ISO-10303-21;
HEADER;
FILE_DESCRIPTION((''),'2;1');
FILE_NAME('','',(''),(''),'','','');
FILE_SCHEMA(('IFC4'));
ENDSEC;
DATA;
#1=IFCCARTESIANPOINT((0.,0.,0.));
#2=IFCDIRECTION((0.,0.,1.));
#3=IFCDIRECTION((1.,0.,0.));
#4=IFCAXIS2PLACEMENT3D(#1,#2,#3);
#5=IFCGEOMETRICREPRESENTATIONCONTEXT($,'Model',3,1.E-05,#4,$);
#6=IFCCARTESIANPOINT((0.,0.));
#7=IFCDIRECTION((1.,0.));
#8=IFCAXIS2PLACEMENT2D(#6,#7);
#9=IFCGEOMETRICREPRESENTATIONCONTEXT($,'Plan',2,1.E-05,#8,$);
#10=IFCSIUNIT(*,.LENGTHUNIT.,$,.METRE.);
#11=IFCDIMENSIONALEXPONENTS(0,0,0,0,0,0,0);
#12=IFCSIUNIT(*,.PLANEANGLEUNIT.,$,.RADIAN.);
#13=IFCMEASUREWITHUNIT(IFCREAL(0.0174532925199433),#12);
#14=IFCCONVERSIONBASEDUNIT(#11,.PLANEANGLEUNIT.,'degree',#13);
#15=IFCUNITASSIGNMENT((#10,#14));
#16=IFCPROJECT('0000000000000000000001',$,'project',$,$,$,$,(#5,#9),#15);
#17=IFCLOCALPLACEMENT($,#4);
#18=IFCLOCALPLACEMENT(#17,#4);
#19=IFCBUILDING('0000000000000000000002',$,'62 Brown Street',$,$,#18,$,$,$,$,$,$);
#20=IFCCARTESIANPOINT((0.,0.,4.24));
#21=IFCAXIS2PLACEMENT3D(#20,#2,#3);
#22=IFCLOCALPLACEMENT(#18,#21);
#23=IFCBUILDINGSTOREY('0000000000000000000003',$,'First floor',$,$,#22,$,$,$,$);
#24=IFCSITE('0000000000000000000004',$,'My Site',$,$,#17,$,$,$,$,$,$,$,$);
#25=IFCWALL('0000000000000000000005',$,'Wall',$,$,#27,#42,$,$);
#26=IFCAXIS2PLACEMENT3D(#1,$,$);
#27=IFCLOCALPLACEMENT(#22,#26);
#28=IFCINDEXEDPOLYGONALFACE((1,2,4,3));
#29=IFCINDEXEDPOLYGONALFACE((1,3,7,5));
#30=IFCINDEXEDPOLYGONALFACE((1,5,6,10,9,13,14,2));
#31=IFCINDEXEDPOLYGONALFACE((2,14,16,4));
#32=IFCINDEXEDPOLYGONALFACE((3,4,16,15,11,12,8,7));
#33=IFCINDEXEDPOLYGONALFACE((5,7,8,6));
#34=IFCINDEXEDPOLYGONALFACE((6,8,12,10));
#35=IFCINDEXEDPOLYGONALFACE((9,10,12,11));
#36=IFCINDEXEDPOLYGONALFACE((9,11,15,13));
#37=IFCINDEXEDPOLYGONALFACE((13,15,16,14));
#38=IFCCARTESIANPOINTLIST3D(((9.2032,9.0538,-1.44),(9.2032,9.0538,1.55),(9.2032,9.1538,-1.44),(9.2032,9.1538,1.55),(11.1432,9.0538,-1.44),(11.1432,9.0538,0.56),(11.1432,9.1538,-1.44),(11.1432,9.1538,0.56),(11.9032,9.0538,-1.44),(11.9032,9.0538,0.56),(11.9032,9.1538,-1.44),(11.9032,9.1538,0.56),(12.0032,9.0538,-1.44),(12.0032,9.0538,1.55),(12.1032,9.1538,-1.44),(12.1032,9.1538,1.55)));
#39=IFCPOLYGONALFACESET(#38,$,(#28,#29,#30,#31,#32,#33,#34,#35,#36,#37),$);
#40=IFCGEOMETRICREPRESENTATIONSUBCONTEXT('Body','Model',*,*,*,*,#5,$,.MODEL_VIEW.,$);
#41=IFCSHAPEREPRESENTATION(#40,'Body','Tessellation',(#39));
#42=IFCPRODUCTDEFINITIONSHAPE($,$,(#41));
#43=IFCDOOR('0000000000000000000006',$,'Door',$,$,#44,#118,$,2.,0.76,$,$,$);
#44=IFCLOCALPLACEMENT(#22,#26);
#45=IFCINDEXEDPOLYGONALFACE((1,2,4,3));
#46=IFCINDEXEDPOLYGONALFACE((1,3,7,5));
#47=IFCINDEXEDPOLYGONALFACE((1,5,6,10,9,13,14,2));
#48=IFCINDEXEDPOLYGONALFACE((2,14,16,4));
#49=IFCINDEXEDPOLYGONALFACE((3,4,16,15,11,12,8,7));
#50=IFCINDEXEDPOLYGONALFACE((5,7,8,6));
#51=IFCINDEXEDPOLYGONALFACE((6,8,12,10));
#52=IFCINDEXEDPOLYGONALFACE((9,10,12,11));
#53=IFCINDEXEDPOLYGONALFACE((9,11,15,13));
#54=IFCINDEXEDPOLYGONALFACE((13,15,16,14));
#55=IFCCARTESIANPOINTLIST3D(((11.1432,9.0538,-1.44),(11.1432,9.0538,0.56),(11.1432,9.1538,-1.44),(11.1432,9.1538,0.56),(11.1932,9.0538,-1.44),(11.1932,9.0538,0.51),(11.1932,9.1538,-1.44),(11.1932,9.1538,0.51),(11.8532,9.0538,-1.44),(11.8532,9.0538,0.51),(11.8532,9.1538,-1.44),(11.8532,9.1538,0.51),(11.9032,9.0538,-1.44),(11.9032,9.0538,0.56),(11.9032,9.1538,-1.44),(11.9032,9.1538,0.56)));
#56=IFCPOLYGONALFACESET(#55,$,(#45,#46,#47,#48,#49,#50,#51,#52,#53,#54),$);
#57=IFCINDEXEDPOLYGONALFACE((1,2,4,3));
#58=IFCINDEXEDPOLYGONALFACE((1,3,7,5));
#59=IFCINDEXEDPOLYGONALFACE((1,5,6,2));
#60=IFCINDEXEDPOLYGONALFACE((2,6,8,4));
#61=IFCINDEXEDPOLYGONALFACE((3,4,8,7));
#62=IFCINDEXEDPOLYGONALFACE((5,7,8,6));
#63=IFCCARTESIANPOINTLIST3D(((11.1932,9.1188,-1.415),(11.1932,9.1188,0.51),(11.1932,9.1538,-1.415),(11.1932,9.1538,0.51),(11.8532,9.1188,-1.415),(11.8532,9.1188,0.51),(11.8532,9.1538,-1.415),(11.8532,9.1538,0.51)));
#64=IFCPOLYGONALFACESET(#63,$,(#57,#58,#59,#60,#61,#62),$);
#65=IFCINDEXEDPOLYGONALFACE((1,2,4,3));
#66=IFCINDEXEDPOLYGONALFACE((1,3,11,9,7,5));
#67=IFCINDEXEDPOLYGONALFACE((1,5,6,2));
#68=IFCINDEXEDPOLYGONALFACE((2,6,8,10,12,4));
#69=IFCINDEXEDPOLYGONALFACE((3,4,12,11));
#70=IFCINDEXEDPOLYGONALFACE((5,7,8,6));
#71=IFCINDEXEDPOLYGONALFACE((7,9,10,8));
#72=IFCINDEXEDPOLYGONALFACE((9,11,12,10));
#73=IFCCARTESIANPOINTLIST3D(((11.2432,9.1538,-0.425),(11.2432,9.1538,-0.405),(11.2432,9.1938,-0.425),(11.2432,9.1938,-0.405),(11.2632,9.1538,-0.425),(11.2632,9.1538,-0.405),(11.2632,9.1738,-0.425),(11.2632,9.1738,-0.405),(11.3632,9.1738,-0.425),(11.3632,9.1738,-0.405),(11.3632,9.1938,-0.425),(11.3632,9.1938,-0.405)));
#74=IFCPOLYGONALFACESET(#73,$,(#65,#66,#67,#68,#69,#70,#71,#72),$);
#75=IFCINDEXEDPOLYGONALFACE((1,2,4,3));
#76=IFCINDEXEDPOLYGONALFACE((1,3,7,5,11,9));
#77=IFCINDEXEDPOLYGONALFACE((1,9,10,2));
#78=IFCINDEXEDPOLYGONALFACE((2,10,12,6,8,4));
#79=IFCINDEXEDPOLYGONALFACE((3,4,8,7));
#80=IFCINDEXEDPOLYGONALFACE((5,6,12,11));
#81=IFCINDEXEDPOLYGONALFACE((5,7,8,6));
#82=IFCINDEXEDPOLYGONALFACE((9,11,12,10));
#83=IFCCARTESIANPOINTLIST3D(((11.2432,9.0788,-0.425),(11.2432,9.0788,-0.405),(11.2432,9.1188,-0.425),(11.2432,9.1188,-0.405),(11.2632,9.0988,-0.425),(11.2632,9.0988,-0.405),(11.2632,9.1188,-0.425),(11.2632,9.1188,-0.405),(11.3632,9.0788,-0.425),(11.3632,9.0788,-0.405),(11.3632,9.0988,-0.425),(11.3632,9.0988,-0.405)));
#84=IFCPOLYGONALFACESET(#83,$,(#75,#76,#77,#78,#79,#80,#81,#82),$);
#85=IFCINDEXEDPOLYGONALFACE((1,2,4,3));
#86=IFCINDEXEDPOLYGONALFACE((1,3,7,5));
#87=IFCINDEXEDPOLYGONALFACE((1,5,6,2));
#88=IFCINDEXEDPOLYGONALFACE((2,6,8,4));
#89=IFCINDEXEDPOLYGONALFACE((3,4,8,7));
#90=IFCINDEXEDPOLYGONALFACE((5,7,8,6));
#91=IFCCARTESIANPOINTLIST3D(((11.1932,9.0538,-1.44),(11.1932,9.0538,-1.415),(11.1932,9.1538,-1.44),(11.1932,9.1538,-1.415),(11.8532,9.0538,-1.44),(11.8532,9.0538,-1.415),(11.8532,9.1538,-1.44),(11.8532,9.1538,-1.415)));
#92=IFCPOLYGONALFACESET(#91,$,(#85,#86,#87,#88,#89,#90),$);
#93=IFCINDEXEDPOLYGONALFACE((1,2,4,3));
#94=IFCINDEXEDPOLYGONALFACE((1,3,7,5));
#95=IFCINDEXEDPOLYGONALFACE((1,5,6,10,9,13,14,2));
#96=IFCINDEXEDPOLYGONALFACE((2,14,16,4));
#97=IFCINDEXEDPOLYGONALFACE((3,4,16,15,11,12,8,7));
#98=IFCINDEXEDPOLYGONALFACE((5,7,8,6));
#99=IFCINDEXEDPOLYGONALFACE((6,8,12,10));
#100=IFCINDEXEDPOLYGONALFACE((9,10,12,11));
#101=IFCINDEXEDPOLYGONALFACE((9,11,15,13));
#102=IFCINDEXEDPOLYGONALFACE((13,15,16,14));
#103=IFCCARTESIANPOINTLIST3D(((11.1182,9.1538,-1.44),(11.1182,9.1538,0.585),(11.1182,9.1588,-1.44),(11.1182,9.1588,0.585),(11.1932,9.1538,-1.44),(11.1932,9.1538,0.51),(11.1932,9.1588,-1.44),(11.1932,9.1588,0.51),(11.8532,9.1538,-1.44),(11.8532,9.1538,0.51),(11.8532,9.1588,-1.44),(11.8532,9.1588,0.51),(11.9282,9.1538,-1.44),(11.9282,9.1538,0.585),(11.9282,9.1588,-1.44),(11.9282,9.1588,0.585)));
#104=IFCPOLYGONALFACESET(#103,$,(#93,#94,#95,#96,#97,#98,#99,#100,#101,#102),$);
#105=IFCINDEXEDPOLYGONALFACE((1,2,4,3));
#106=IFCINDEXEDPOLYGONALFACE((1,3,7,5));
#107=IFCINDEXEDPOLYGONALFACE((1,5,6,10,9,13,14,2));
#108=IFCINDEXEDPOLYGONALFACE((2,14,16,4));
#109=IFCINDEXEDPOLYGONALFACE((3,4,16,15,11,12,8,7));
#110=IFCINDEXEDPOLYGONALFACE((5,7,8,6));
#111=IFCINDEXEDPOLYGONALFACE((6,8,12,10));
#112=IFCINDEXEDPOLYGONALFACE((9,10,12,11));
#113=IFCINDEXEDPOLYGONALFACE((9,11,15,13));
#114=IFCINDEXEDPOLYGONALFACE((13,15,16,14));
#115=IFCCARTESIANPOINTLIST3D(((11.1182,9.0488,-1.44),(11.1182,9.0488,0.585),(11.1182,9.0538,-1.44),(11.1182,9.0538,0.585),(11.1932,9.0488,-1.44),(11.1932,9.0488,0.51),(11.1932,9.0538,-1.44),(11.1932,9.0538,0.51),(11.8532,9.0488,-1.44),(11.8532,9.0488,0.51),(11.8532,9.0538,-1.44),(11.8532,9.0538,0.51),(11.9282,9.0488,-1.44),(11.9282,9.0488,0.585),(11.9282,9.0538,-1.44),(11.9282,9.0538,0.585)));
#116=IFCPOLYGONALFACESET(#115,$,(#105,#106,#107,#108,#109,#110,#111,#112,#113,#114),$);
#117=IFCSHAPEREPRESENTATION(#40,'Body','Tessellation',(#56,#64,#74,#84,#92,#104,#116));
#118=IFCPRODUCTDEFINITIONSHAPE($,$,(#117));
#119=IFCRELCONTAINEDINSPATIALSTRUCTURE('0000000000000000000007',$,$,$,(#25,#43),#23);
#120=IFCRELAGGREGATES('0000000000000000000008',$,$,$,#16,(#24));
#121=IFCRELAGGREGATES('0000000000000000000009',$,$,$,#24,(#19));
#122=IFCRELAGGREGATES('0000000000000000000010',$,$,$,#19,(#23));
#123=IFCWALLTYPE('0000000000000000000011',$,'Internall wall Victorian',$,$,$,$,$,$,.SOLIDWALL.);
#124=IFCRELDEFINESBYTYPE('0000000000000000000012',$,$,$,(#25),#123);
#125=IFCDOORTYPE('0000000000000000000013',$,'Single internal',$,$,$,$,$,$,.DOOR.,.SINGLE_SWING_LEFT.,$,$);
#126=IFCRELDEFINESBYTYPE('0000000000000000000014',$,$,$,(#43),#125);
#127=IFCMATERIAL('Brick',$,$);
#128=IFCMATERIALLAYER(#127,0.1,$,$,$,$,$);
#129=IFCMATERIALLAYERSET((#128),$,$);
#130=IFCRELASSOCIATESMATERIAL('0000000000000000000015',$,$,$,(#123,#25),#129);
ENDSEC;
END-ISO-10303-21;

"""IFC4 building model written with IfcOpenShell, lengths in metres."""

from ifc_helpers import new_model, entity, si_unit, converted_unit, frame, origin_with_axes, origin_2d_with_axis, place, context, subcontext, project, spatial, line, indexed_curve, outline, extrude, clip, halfspace, shape, source, transform, mapped, material, layer, layer_set, layer_usage, type_object, type_shapes, element, fill, save


model = new_model("IFC4")

# Units and contexts
model_context = context("Model", 3, precision=1e-05, world=origin_with_axes())
plan_context = context("Plan", 2, precision=1e-05, world=origin_2d_with_axis())
body_context_1 = subcontext(model_context, "Body", "Model", "MODEL_VIEW")
body_context_2 = subcontext(plan_context, "Body", "Plan", "PLAN_VIEW")
ifc_project = project(units=[si_unit("LENGTHUNIT", "METRE"), converted_unit("PLANEANGLEUNIT", "degree", entity("IfcReal", 0.0174532925199433), si_unit("PLANEANGLEUNIT", "RADIAN"), dimensions=[0, 0, 0, 0, 0, 0, 0])], contexts=[model_context, plan_context])

# Site, building, storey
site_placement = place(None, origin_with_axes())
site = spatial("IfcSite", under=ifc_project, at=site_placement, Name="My Site")
building_placement = place(site_placement, origin_with_axes())
building = spatial("IfcBuilding", under=site, at=building_placement, Name="62 Brown Street")
storey_placement = place(building_placement, frame((0.0, 0.0, 4.24), z_axis=(0.0, 0.0, 1.0), x_axis=(1.0, 0.0, 0.0)))
storey = spatial("IfcBuildingStorey", under=building, at=storey_placement, Name="First floor")

# Shared definitions
ifc_material_1 = material(Name="Brick")

# Shared definitions
ifc_layer_1 = layer(ifc_material_1, 0.1)
ifc_layer_set_1 = layer_set([ifc_layer_1])
wall_type_1 = type_object("IfcWallType", Name="Internall wall Victorian", PredefinedType="SOLIDWALL", material=ifc_layer_set_1)

# Wall, opening, door
ifc_layer_usage_1 = layer_usage(ifc_layer_set_1, "AXIS2", "POSITIVE", 0.0)
wall_1_placement = place(storey_placement, frame((12.1032, 9.1538, -1.44), z_axis=(0.0, 0.0, 1.0), x_axis=(-1.0, 0.0, 0.0)))
wall_1 = element("IfcWall", 1, at=wall_1_placement, inside=storey, type_object=wall_type_1, material=ifc_layer_usage_1, Name="Wall", context=body_context_1, shape_type="Clipping", body=[
    clip(extrude(outline(indexed_curve([(0.0, 0.0), (0.0, 0.1), (2.9, 0.1), (2.9, 0.0), (0.0, 0.0)], self_intersect=False)), origin_with_axes(), (0.0, 0.0, 1.0), 2.99), halfspace(frame((0.0, 0.0, -2.8), z_axis=(-0.299001, 0.299001, 0.0), x_axis=(0.1, 0.1, 0.0)), False)),
])
shared_shape_1 = source(origin_with_axes(), body_context_1, "Body", "SweptSolid", [
    extrude(outline(indexed_curve([(0.0, 0.0), (0.76, 0.0), (0.76, 2.0), (0.0, 2.0)], segments=[line(1, 2, 3, 4, 1)])), frame((0.0, -0.6, 0.0), z_axis=(0.0, -1.0, 0.0), x_axis=(1.0, 0.0, 0.0)), (0.0, 0.0, -1.0), 1.2),
])
opening_1_placement = place(wall_1_placement, frame((0.2, 0.0, 0.0), z_axis=(0.0, 0.0, 1.0), x_axis=(1.0, 0.0, 0.0)))
opening_1 = element("IfcOpeningElement", 2, at=opening_1_placement, cuts=wall_1, PredefinedType="OPENING", context=body_context_1, shape_type="MappedRepresentation", body=[
    mapped(shared_shape_1, transform((0.0, 0.0, 0.0), x_axis=(1.0, 0.0, 0.0), y_axis=(0.0, 1.0, 0.0), z_axis=(0.0, 0.0, 1.0), scale=1.0)),
])
door_type_1 = type_object("IfcDoorType", Name="Single internal", OperationType="SINGLE_SWING_LEFT", PredefinedType="DOOR")
shared_shape_2 = source(origin_with_axes(), body_context_1, "Body", "SweptSolid", [
    extrude(outline(indexed_curve([(0.0, 0.0), (0.0, 2.0), (0.76, 2.0), (0.76, 0.0), (0.71, 0.0), (0.71, 1.95), (0.05, 1.95), (0.05, 0.0)], segments=[line(1, 2, 3, 4, 5, 6, 7, 8, 1)])), frame((0.0, 0.0, 0.0), z_axis=(0.0, -1.0, 0.0), x_axis=(1.0, 0.0, 0.0)), (0.0, 0.0, -1.0), 0.1),
    extrude(outline(indexed_curve([(0.0, 0.0), (0.66, 0.0), (0.66, 0.035), (0.0, 0.035)], segments=[line(1, 2, 3, 4, 1)])), frame((0.05, 0.0, 0.025), z_axis=(0.0, 0.0, 1.0), x_axis=(1.0, 0.0, 0.0)), (0.0, 0.0, 1.0), 1.925),
    extrude(outline(indexed_curve([(0.0, 0.0), (0.0, -0.04), (-0.12, -0.04), (-0.12, -0.02), (-0.02, -0.02), (-0.02, 0.0)], segments=[line(1, 2, 3, 4, 5, 6, 1)])), frame((0.66, 0.0, 1.015), z_axis=(0.0, 0.0, 1.0), x_axis=(1.0, 0.0, 0.0)), (0.0, 0.0, 1.0), 0.02),
    extrude(outline(indexed_curve([(0.0, 0.0), (0.0, 0.04), (-0.12, 0.04), (-0.12, 0.02), (-0.02, 0.02), (-0.02, 0.0)], segments=[line(1, 2, 3, 4, 5, 6, 1)])), frame((0.66, 0.035, 1.015), z_axis=(0.0, 0.0, 1.0), x_axis=(1.0, 0.0, 0.0)), (0.0, 0.0, 1.0), 0.02),
    extrude(outline(indexed_curve([(0.0, 0.0), (0.66, 0.0), (0.66, 0.1), (0.0, 0.1)], segments=[line(1, 2, 3, 4, 1)])), frame((0.05, 0.0, 0.0), z_axis=(0.0, 0.0, 1.0), x_axis=(1.0, 0.0, 0.0)), (0.0, 0.0, 1.0), 0.025),
    extrude(outline(indexed_curve([(0.0, 0.0), (0.0, 2.025), (0.81, 2.025), (0.81, 0.0), (0.735, 0.0), (0.735, 1.95), (0.075, 1.95), (0.075, 0.0)], segments=[line(1, 2, 3, 4, 5, 6, 7, 8, 1)])), frame((-0.025, -0.005, 0.0), z_axis=(0.0, -1.0, 0.0), x_axis=(1.0, 0.0, 0.0)), (0.0, 0.0, -1.0), 0.005),
    extrude(outline(indexed_curve([(0.0, 0.0), (0.0, 2.025), (0.81, 2.025), (0.81, 0.0), (0.735, 0.0), (0.735, 1.95), (0.075, 1.95), (0.075, 0.0)], segments=[line(1, 2, 3, 4, 5, 6, 7, 8, 1)])), frame((-0.025, 0.1, 0.0), z_axis=(0.0, -1.0, 0.0), x_axis=(1.0, 0.0, 0.0)), (0.0, 0.0, -1.0), 0.005),
])
shared_shape_3 = source(origin_with_axes(), body_context_2, "Body", "Curve2D", [
    entity("IfcIndexedPolyCurve", entity("IfcCartesianPointList2D", [[0.0, 0.0], [0.05, 0.0], [0.05, 0.1], [0.0, 0.1]]), [entity("IfcLineIndex", [1, 2, 3, 4, 1])]),
    entity("IfcIndexedPolyCurve", entity("IfcCartesianPointList2D", [[0.76, 0.0], [0.71, 0.0], [0.71, 0.1], [0.76, 0.1]]), [entity("IfcLineIndex", [1, 2, 3, 4, 1])]),
    entity("IfcTrimmedCurve", entity("IfcEllipse", entity("IfcAxis2Placement2D", entity("IfcCartesianPoint", [0.085, 0.1]), entity("IfcDirection", [1.0, 0.0])), 0.625, 0.66), [entity("IfcCartesianPoint", [0.71, 0.1])], [entity("IfcCartesianPoint", [0.085, 0.76])], True, "CARTESIAN"),
    entity("IfcIndexedPolyCurve", entity("IfcCartesianPointList2D", [[0.05, 0.1], [0.085, 0.1], [0.085, 0.76], [0.05, 0.76]]), [entity("IfcLineIndex", [1, 2, 3, 4, 1])]),
])
type_shapes(door_type_1, [shared_shape_2, shared_shape_3])
door_1_placement = place(opening_1_placement, frame((0.0, 0.0, 0.0), z_axis=(0.0, 0.0, 1.0), x_axis=(1.0, 0.0, 0.0)))
door_1 = element("IfcDoor", 3, at=door_1_placement, inside=storey, type_object=door_type_1, Name="Door", OverallHeight=2.0, OverallWidth=0.76, shapes=[
    shape(body_context_1, "Body", "MappedRepresentation", [mapped(shared_shape_2, transform((0.0, 0.0, 0.0), x_axis=(1.0, 0.0, 0.0), y_axis=(0.0, 1.0, 0.0), z_axis=(0.0, 0.0, 1.0), scale=1.0))]),
    shape(body_context_2, "Body", "MappedRepresentation", [mapped(shared_shape_3, transform((0.0, 0.0, 0.0), x_axis=(1.0, 0.0, 0.0), y_axis=(0.0, 1.0, 0.0), z_axis=(0.0, 0.0, 1.0), scale=1.0))]),
])
fill(opening_1, door_1)

save(model, "model.ifc")
